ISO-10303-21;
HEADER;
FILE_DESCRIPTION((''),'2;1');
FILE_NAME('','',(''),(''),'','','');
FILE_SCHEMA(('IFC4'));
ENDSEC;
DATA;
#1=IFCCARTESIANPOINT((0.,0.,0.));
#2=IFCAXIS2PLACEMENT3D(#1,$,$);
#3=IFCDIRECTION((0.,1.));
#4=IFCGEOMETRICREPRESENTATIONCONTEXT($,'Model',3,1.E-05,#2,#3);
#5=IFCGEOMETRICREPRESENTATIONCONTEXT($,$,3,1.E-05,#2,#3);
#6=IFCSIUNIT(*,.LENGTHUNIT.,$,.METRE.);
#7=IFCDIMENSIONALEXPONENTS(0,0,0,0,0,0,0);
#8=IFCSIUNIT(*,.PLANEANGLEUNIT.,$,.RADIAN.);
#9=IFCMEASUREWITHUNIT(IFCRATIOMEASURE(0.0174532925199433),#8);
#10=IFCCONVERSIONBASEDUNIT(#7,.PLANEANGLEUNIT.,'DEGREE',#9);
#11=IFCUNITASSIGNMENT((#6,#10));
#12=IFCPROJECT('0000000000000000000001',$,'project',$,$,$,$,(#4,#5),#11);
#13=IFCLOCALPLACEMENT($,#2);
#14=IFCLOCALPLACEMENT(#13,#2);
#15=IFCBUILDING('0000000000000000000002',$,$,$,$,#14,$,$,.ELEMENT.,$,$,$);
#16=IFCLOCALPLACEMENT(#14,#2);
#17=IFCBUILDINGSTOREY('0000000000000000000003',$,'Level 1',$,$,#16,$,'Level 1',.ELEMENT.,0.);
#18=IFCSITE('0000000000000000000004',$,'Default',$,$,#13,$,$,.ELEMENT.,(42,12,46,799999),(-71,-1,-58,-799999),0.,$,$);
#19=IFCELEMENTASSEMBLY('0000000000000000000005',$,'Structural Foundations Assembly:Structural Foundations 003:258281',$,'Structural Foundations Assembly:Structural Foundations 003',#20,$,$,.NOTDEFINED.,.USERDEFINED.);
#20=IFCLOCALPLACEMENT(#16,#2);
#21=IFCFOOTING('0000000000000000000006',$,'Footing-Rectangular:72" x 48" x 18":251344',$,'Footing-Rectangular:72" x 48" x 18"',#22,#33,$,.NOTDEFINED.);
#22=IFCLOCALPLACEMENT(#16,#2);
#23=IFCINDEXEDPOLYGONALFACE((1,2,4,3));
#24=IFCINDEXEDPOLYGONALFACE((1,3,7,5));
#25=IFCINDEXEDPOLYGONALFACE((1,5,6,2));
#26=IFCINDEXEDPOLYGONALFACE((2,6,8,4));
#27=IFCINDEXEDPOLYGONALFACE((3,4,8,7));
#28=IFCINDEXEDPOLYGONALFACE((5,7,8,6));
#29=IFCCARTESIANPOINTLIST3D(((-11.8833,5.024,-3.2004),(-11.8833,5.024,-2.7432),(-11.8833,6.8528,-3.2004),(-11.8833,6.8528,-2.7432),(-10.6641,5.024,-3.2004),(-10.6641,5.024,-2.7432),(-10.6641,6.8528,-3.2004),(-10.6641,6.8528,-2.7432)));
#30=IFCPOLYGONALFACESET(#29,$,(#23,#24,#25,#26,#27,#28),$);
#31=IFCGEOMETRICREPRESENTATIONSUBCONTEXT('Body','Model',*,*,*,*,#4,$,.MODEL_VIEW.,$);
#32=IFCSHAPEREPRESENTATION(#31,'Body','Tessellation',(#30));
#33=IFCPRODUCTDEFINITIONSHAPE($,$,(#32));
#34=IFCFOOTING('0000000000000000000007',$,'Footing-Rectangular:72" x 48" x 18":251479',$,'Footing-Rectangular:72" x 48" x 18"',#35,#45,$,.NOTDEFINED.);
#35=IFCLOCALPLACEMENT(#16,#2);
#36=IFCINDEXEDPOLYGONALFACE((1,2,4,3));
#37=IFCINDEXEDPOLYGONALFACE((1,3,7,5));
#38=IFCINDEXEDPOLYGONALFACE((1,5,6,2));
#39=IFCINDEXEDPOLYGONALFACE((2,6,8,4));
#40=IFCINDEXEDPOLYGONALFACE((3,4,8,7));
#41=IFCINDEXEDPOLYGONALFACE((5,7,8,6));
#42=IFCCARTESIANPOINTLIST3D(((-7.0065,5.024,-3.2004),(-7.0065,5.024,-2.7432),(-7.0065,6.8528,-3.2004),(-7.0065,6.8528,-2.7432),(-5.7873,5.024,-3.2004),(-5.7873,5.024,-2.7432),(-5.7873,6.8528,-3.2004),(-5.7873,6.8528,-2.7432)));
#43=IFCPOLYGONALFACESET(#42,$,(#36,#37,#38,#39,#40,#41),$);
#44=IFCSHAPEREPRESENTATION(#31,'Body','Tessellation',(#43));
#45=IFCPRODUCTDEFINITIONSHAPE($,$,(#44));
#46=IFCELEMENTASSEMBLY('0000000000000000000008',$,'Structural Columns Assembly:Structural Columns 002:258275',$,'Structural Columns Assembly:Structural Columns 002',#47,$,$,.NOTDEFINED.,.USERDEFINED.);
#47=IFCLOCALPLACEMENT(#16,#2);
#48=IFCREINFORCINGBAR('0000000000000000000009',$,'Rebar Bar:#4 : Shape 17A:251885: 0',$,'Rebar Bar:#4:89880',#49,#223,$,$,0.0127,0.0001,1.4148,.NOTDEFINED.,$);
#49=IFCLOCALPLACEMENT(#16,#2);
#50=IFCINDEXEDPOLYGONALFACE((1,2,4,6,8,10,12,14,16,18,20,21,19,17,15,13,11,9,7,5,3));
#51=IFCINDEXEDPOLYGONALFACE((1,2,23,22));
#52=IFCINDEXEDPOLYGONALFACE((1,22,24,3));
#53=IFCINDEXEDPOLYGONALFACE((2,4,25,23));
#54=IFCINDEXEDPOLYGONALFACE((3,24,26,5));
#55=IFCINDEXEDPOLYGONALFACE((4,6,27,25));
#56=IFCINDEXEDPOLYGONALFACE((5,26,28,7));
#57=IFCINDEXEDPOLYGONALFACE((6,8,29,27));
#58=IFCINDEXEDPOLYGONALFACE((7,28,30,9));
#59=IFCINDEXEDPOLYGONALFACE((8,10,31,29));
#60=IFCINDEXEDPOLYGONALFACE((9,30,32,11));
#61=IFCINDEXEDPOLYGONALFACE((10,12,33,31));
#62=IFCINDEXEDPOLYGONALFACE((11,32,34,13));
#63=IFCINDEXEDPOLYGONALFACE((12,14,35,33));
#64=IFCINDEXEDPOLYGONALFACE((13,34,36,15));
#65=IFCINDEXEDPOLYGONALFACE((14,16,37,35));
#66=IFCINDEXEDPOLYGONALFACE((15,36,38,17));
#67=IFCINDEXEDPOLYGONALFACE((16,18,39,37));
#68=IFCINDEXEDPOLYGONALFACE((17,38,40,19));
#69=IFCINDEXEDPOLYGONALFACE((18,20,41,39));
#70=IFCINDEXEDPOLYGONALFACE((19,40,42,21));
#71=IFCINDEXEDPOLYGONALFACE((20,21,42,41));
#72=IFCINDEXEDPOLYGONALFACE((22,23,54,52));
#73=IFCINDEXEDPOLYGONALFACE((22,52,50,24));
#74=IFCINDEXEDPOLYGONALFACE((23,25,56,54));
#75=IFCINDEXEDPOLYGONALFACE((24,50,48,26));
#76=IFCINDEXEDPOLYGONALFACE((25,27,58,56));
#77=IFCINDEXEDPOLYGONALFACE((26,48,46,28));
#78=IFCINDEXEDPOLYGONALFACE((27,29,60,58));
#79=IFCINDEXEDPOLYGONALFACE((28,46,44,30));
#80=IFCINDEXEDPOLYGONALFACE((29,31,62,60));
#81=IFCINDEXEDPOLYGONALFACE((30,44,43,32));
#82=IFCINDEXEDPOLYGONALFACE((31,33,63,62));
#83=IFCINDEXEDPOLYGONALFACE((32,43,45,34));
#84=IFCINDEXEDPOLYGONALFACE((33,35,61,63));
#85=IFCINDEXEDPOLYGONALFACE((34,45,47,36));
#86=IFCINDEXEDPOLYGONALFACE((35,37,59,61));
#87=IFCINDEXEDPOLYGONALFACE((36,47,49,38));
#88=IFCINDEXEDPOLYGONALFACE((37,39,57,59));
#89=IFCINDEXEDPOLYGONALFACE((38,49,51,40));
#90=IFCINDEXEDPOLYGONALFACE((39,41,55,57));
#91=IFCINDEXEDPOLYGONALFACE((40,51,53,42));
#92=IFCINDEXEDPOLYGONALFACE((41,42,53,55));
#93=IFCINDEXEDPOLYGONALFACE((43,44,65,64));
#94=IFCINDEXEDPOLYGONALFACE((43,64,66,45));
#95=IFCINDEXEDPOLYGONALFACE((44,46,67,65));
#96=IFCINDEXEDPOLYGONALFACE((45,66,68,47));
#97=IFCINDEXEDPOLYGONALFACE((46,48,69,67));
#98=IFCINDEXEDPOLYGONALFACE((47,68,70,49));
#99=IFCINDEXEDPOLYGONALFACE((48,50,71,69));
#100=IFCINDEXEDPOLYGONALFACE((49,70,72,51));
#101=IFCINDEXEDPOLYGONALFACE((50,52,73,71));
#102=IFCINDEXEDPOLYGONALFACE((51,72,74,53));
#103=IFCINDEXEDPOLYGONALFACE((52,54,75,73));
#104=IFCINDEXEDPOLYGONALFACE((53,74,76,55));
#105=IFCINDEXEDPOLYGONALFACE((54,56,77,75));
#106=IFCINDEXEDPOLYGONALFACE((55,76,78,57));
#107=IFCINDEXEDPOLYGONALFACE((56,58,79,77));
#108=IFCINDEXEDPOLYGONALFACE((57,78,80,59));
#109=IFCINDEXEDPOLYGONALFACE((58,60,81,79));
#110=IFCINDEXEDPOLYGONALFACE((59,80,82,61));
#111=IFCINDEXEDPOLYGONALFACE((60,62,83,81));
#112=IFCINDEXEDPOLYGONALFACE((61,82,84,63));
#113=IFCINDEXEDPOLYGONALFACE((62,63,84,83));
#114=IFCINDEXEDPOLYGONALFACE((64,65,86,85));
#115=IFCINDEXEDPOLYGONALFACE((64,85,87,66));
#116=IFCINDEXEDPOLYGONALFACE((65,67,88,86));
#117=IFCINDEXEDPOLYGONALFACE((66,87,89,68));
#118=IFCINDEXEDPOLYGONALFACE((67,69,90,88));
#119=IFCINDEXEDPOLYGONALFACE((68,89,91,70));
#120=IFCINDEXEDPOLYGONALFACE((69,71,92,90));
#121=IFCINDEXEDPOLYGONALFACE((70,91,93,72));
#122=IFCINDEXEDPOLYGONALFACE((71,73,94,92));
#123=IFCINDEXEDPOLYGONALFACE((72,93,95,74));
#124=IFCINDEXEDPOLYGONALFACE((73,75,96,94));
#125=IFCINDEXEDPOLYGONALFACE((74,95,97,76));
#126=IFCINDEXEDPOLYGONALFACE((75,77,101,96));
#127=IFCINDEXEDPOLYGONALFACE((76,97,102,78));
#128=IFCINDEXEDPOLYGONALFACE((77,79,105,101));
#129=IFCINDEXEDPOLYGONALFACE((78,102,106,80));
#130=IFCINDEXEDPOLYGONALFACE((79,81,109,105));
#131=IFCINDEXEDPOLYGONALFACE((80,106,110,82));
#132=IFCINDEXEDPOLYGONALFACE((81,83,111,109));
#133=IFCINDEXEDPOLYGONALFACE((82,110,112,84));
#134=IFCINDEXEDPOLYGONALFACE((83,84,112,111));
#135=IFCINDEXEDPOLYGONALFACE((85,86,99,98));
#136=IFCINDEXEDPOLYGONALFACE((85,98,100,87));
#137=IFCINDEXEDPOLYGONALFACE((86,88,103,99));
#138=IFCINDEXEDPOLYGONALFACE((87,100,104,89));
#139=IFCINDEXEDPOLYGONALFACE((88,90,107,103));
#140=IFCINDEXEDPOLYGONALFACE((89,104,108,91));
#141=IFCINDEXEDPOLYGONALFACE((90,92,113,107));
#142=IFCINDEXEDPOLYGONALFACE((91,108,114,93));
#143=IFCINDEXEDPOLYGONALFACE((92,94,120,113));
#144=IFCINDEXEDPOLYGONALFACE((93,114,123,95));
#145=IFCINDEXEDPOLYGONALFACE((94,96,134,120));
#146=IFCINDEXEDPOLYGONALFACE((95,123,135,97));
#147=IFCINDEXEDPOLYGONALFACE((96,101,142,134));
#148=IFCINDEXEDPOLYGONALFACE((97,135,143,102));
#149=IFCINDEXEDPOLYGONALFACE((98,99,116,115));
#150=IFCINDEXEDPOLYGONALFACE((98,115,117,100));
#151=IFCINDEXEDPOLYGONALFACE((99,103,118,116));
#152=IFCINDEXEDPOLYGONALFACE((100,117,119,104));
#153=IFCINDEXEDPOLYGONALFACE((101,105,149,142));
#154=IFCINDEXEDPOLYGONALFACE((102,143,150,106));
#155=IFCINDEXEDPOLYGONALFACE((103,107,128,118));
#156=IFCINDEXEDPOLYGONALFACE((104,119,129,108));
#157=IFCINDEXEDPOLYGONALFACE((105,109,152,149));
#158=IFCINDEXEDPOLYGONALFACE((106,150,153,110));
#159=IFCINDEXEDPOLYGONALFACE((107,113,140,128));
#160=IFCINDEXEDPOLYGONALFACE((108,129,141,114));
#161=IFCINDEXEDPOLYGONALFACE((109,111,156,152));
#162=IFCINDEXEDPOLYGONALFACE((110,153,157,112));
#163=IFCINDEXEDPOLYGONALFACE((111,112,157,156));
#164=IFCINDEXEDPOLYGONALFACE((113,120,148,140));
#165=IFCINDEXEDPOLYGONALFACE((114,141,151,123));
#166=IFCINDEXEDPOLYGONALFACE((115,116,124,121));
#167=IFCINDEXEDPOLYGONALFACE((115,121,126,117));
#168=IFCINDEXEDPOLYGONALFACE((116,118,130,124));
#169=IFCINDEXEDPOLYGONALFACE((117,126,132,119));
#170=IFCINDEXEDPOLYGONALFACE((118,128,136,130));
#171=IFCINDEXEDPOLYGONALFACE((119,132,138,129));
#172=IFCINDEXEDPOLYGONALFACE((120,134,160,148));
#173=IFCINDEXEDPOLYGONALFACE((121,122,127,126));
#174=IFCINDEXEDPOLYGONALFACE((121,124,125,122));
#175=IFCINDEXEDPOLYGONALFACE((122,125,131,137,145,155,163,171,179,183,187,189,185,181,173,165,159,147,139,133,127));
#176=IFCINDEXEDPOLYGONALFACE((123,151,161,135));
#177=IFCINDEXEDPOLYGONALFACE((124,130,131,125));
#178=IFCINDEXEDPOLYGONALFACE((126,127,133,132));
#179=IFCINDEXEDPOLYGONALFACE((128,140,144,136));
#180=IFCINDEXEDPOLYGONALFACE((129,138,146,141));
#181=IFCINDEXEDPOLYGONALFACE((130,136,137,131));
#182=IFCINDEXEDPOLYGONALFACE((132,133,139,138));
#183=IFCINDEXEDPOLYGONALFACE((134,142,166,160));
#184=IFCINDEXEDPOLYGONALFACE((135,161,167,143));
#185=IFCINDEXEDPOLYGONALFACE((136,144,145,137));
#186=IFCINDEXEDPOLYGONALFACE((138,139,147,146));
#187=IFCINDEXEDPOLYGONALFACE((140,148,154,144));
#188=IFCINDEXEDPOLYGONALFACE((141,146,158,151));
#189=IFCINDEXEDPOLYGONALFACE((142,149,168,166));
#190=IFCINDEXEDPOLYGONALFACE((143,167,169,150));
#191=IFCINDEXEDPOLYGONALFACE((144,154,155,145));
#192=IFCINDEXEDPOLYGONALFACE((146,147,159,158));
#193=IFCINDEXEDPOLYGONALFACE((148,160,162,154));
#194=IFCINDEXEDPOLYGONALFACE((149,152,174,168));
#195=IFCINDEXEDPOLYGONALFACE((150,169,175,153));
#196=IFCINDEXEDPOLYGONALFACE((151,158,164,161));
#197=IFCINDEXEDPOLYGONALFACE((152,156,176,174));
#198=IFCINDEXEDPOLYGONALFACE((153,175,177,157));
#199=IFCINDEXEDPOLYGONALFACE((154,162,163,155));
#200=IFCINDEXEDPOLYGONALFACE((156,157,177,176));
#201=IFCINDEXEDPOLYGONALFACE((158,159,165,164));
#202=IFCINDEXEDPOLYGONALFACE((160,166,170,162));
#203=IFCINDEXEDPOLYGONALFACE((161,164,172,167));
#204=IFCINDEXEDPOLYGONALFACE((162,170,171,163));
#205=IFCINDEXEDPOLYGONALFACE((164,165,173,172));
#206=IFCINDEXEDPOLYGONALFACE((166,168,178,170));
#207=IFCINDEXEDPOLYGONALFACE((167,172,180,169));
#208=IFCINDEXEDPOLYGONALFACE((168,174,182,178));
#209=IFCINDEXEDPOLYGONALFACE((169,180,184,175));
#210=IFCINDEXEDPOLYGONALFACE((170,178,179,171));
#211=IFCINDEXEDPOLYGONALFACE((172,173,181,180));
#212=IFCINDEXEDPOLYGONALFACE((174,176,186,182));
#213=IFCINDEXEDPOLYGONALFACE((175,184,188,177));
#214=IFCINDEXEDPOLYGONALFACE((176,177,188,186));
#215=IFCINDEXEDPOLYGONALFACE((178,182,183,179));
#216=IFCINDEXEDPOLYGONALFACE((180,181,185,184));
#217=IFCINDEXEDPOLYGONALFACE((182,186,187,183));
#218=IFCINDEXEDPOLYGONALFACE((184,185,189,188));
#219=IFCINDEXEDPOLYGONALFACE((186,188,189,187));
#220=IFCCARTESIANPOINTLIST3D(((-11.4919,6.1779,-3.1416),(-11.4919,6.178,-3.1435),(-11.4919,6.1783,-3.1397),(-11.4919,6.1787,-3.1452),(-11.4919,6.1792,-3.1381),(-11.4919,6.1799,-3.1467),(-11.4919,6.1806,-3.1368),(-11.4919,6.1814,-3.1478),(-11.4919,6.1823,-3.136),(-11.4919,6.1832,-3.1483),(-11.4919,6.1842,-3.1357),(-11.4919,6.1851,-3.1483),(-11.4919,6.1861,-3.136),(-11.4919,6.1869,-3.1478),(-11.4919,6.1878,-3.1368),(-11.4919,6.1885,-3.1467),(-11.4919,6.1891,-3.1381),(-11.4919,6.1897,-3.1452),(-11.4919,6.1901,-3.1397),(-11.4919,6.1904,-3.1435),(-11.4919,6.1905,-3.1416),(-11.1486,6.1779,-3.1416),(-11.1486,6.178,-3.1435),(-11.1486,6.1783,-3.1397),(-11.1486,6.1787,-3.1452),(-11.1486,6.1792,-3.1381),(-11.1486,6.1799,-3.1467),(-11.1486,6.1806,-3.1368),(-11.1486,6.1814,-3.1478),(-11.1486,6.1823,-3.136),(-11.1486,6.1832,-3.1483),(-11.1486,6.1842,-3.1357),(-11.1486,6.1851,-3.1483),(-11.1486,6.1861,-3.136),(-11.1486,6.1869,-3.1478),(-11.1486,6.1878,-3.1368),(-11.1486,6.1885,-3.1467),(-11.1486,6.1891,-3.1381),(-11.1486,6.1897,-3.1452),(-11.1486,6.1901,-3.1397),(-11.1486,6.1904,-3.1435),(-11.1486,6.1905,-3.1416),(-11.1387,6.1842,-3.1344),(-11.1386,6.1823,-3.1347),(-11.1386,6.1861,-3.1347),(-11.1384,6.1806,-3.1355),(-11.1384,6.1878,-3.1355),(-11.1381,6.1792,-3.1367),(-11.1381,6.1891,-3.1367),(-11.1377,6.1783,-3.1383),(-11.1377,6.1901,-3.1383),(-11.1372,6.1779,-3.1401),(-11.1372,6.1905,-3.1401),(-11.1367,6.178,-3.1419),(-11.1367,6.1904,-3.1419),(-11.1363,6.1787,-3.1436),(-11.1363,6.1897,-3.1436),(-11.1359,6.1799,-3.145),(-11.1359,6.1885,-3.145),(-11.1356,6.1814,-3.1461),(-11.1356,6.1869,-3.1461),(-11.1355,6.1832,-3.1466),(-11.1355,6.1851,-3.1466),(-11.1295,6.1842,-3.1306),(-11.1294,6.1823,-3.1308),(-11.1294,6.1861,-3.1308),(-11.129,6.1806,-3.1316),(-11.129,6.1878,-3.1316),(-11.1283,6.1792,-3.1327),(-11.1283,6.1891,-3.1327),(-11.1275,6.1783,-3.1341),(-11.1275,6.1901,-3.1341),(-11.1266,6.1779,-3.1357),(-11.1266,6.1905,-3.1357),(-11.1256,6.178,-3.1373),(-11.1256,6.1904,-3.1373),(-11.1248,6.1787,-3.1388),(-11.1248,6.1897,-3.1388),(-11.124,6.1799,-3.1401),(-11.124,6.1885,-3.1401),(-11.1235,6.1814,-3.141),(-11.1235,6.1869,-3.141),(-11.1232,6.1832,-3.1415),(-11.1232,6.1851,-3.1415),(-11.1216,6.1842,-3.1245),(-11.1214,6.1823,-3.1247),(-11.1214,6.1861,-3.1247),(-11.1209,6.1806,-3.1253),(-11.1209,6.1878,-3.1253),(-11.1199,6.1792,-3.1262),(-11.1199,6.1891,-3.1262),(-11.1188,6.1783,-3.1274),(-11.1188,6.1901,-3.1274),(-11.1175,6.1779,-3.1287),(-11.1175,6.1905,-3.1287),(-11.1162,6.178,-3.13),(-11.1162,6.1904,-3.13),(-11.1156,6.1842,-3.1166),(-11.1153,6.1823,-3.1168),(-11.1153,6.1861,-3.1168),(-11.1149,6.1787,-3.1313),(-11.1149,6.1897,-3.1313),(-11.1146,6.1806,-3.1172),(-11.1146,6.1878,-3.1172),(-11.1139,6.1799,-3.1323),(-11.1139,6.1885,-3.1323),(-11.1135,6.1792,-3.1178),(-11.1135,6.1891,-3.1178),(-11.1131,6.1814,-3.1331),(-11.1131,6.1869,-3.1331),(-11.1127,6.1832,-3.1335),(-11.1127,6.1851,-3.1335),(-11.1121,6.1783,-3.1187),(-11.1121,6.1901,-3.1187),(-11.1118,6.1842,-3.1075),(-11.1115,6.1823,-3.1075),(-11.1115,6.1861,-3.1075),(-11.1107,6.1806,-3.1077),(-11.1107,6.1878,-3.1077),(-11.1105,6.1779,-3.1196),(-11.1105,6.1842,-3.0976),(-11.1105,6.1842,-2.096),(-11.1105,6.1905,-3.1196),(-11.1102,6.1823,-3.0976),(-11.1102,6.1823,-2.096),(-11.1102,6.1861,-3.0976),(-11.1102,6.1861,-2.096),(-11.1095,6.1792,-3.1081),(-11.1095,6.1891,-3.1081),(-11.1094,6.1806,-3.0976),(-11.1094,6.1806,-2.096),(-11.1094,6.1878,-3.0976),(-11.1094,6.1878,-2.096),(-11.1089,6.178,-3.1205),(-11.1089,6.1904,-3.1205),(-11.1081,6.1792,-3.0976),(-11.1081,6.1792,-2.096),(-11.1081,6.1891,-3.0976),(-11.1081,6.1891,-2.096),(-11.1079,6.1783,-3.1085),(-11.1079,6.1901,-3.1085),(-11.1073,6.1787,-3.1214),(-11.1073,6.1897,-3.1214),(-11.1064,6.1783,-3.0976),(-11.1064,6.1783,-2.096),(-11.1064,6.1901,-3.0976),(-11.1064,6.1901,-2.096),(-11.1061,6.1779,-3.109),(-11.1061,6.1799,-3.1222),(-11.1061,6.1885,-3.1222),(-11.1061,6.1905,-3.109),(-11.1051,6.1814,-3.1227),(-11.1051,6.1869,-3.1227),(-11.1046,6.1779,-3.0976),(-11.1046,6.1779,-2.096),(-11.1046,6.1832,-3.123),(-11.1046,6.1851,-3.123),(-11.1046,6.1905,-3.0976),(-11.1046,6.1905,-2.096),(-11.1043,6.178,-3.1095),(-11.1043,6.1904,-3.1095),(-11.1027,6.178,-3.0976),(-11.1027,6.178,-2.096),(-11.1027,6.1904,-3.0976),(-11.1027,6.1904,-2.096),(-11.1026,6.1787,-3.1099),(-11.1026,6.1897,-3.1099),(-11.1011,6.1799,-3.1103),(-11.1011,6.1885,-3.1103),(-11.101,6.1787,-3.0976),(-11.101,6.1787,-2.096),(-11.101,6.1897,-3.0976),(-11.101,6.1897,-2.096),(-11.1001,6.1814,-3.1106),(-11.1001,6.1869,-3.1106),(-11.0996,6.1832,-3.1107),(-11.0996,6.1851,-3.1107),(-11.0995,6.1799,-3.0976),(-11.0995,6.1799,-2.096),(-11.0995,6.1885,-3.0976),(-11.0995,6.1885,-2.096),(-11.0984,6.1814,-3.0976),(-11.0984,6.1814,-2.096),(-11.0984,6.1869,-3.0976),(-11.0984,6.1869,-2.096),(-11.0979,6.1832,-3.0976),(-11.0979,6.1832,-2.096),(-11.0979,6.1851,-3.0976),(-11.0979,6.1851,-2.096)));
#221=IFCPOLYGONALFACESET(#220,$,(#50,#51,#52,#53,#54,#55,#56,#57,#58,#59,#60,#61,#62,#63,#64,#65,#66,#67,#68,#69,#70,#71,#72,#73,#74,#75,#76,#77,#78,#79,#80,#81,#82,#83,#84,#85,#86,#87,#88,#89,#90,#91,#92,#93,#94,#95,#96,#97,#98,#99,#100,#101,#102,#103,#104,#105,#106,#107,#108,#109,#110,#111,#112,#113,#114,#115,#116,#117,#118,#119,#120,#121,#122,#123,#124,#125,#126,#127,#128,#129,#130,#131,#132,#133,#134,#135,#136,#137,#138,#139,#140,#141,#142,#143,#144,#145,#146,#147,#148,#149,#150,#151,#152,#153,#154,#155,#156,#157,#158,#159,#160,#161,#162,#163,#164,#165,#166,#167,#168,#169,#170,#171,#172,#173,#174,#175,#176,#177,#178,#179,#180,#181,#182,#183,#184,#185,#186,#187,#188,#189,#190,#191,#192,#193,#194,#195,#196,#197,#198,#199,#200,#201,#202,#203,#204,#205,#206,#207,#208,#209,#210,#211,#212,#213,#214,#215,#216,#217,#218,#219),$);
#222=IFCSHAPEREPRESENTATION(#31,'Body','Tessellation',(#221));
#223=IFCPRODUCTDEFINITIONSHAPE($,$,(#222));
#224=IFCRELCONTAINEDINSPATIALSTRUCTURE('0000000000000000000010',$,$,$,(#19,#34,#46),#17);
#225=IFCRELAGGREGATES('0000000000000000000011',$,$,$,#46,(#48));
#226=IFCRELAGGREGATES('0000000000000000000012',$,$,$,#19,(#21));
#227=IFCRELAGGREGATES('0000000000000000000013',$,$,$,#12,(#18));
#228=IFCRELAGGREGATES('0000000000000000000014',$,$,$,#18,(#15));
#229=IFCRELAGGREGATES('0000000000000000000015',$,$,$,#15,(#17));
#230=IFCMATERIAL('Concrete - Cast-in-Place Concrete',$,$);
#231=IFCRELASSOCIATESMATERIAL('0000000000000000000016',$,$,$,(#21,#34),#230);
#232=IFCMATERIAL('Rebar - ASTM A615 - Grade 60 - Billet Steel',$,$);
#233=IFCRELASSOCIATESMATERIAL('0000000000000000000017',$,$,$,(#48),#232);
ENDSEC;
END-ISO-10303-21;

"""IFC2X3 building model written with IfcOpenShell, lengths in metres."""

from ifc_helpers import new_model, entity, si_unit, converted_unit, direction, frame, origin, origin_2d_with_axis, place, context, subcontext, project, spatial, rectangle, extrude, material, element, aggregate, save


model = new_model("IFC2X3")

# Units and contexts
model_context = context("Model", 3, precision=1e-05, world=origin(), true_north=direction((0.0, 1.0)))
context_of_model = context(None, 3, precision=1e-05, world=origin(), true_north=direction((0.0, 1.0)))
body_context = subcontext(model_context, "Body", "Model", "MODEL_VIEW")
ifc_project = project(units=[si_unit("LENGTHUNIT", "METRE"), converted_unit("PLANEANGLEUNIT", "DEGREE", entity("IfcRatioMeasure", 0.0174532925199433), si_unit("PLANEANGLEUNIT", "RADIAN"), dimensions=[0, 0, 0, 0, 0, 0, 0])], contexts=[model_context, context_of_model])

# Site, building, storey
site_placement = place(None, origin())
site = spatial("IfcSite", under=ifc_project, at=site_placement, Name="Default", CompositionType="ELEMENT", RefLatitude=(42, 12, 46, 799999), RefLongitude=(-71, -1, -58, -799999), RefElevation=0.0)
building_placement = place(site_placement, origin())
building = spatial("IfcBuilding", under=site, at=building_placement, CompositionType="ELEMENT")
storey_placement = place(building_placement, origin())
storey = spatial("IfcBuildingStorey", under=building, at=storey_placement, Name="Level 1", LongName="Level 1", CompositionType="ELEMENT", Elevation=0.0)

# Element assembly, footing
assembly_1_placement = place(storey_placement, origin())
assembly_1 = element("IfcElementAssembly", 1, at=assembly_1_placement, inside=storey, Name="Structural Foundations Assembly:Structural Foundations 003:258281", ObjectType="Structural Foundations Assembly:Structural Foundations 003", AssemblyPlace="NOTDEFINED", PredefinedType="USERDEFINED")
ifc_material_1 = material(Name="Concrete - Cast-in-Place Concrete")
footing_1_placement = place(assembly_1_placement, origin())
footing_1 = element("IfcFooting", 2, at=footing_1_placement, material=ifc_material_1, Name="Footing-Rectangular:72\" x 48\" x 18\":251344", ObjectType="Footing-Rectangular:72\" x 48\" x 18\"", PredefinedType="NOTDEFINED", context=body_context, shape_type="SweptSolid", body=[
    extrude(rectangle(XDim=1.2192, YDim=1.8288, at=origin_2d_with_axis()), frame((-11.2737, 5.9384, -3.2004), z_axis=(0.0, 0.0, 1.0), x_axis=(-1.0, 0.0, 0.0)), (0.0, 0.0, 1.0), 0.4572),
])

# Footing
footing_2_placement = place(storey_placement, origin())
element("IfcFooting", 3, at=footing_2_placement, inside=storey, material=ifc_material_1, Name="Footing-Rectangular:72\" x 48\" x 18\":251479", ObjectType="Footing-Rectangular:72\" x 48\" x 18\"", PredefinedType="NOTDEFINED", context=body_context, shape_type="SweptSolid", body=[
    extrude(rectangle(XDim=1.2192, YDim=1.8288, at=origin_2d_with_axis()), frame((-6.3969, 5.9384, -3.2004), z_axis=(0.0, 0.0, 1.0), x_axis=(-1.0, 0.0, 0.0)), (0.0, 0.0, 1.0), 0.4572),
])

# Element assembly, reinforcing bar
assembly_2_placement = place(storey_placement, origin())
assembly_2 = element("IfcElementAssembly", 4, at=assembly_2_placement, inside=storey, Name="Structural Columns Assembly:Structural Columns 002:258275", ObjectType="Structural Columns Assembly:Structural Columns 002", AssemblyPlace="NOTDEFINED", PredefinedType="USERDEFINED")
ifc_material_2 = material(Name="Rebar - ASTM A615 - Grade 60 - Billet Steel")
reinforcing_bar_1_placement = place(assembly_2_placement, origin())
reinforcing_bar_1 = element("IfcReinforcingBar", 5, at=reinforcing_bar_1_placement, material=ifc_material_2, Name="Rebar Bar:#4 : Shape 17A:251885: 0", ObjectType="Rebar Bar:#4:89880", BarLength=1.4148, BarRole="NOTDEFINED", CrossSectionArea=0.0001, NominalDiameter=0.0127, context=body_context, shape_type="AdvancedSweptSolid", body=[
    entity("IfcSweptDiskSolid", entity("IfcCompositeCurve", [entity("IfcCompositeCurveSegment", "CONTINUOUS", True, entity("IfcPolyline", [entity("IfcCartesianPoint", [-11.4919, 6.1842, -3.142]), entity("IfcCartesianPoint", [-11.1486, 6.1842, -3.142])])), entity("IfcCompositeCurveSegment", "CONTINUOUS", True, entity("IfcTrimmedCurve", entity("IfcCircle", entity("IfcAxis2Placement3D", entity("IfcCartesianPoint", [-11.1486, 6.1842, -3.0976]), entity("IfcDirection", [0.0, -1.0, 0.0]), entity("IfcDirection", [1.0, 0.0, 0.0])), 0.0445), [entity("IfcParameterValue", 270.0)], [entity("IfcParameterValue", 360.0)], True, "PARAMETER")), entity("IfcCompositeCurveSegment", "CONTINUOUS", True, entity("IfcPolyline", [entity("IfcCartesianPoint", [-11.1041, 6.1842, -3.0976]), entity("IfcCartesianPoint", [-11.1041, 6.1842, -2.096])]))], False), 0.0063, None, 0.0, 92.0),
])
aggregate(assembly_2, [reinforcing_bar_1])

aggregate(assembly_1, [footing_1])

save(model, "model.ifc")
